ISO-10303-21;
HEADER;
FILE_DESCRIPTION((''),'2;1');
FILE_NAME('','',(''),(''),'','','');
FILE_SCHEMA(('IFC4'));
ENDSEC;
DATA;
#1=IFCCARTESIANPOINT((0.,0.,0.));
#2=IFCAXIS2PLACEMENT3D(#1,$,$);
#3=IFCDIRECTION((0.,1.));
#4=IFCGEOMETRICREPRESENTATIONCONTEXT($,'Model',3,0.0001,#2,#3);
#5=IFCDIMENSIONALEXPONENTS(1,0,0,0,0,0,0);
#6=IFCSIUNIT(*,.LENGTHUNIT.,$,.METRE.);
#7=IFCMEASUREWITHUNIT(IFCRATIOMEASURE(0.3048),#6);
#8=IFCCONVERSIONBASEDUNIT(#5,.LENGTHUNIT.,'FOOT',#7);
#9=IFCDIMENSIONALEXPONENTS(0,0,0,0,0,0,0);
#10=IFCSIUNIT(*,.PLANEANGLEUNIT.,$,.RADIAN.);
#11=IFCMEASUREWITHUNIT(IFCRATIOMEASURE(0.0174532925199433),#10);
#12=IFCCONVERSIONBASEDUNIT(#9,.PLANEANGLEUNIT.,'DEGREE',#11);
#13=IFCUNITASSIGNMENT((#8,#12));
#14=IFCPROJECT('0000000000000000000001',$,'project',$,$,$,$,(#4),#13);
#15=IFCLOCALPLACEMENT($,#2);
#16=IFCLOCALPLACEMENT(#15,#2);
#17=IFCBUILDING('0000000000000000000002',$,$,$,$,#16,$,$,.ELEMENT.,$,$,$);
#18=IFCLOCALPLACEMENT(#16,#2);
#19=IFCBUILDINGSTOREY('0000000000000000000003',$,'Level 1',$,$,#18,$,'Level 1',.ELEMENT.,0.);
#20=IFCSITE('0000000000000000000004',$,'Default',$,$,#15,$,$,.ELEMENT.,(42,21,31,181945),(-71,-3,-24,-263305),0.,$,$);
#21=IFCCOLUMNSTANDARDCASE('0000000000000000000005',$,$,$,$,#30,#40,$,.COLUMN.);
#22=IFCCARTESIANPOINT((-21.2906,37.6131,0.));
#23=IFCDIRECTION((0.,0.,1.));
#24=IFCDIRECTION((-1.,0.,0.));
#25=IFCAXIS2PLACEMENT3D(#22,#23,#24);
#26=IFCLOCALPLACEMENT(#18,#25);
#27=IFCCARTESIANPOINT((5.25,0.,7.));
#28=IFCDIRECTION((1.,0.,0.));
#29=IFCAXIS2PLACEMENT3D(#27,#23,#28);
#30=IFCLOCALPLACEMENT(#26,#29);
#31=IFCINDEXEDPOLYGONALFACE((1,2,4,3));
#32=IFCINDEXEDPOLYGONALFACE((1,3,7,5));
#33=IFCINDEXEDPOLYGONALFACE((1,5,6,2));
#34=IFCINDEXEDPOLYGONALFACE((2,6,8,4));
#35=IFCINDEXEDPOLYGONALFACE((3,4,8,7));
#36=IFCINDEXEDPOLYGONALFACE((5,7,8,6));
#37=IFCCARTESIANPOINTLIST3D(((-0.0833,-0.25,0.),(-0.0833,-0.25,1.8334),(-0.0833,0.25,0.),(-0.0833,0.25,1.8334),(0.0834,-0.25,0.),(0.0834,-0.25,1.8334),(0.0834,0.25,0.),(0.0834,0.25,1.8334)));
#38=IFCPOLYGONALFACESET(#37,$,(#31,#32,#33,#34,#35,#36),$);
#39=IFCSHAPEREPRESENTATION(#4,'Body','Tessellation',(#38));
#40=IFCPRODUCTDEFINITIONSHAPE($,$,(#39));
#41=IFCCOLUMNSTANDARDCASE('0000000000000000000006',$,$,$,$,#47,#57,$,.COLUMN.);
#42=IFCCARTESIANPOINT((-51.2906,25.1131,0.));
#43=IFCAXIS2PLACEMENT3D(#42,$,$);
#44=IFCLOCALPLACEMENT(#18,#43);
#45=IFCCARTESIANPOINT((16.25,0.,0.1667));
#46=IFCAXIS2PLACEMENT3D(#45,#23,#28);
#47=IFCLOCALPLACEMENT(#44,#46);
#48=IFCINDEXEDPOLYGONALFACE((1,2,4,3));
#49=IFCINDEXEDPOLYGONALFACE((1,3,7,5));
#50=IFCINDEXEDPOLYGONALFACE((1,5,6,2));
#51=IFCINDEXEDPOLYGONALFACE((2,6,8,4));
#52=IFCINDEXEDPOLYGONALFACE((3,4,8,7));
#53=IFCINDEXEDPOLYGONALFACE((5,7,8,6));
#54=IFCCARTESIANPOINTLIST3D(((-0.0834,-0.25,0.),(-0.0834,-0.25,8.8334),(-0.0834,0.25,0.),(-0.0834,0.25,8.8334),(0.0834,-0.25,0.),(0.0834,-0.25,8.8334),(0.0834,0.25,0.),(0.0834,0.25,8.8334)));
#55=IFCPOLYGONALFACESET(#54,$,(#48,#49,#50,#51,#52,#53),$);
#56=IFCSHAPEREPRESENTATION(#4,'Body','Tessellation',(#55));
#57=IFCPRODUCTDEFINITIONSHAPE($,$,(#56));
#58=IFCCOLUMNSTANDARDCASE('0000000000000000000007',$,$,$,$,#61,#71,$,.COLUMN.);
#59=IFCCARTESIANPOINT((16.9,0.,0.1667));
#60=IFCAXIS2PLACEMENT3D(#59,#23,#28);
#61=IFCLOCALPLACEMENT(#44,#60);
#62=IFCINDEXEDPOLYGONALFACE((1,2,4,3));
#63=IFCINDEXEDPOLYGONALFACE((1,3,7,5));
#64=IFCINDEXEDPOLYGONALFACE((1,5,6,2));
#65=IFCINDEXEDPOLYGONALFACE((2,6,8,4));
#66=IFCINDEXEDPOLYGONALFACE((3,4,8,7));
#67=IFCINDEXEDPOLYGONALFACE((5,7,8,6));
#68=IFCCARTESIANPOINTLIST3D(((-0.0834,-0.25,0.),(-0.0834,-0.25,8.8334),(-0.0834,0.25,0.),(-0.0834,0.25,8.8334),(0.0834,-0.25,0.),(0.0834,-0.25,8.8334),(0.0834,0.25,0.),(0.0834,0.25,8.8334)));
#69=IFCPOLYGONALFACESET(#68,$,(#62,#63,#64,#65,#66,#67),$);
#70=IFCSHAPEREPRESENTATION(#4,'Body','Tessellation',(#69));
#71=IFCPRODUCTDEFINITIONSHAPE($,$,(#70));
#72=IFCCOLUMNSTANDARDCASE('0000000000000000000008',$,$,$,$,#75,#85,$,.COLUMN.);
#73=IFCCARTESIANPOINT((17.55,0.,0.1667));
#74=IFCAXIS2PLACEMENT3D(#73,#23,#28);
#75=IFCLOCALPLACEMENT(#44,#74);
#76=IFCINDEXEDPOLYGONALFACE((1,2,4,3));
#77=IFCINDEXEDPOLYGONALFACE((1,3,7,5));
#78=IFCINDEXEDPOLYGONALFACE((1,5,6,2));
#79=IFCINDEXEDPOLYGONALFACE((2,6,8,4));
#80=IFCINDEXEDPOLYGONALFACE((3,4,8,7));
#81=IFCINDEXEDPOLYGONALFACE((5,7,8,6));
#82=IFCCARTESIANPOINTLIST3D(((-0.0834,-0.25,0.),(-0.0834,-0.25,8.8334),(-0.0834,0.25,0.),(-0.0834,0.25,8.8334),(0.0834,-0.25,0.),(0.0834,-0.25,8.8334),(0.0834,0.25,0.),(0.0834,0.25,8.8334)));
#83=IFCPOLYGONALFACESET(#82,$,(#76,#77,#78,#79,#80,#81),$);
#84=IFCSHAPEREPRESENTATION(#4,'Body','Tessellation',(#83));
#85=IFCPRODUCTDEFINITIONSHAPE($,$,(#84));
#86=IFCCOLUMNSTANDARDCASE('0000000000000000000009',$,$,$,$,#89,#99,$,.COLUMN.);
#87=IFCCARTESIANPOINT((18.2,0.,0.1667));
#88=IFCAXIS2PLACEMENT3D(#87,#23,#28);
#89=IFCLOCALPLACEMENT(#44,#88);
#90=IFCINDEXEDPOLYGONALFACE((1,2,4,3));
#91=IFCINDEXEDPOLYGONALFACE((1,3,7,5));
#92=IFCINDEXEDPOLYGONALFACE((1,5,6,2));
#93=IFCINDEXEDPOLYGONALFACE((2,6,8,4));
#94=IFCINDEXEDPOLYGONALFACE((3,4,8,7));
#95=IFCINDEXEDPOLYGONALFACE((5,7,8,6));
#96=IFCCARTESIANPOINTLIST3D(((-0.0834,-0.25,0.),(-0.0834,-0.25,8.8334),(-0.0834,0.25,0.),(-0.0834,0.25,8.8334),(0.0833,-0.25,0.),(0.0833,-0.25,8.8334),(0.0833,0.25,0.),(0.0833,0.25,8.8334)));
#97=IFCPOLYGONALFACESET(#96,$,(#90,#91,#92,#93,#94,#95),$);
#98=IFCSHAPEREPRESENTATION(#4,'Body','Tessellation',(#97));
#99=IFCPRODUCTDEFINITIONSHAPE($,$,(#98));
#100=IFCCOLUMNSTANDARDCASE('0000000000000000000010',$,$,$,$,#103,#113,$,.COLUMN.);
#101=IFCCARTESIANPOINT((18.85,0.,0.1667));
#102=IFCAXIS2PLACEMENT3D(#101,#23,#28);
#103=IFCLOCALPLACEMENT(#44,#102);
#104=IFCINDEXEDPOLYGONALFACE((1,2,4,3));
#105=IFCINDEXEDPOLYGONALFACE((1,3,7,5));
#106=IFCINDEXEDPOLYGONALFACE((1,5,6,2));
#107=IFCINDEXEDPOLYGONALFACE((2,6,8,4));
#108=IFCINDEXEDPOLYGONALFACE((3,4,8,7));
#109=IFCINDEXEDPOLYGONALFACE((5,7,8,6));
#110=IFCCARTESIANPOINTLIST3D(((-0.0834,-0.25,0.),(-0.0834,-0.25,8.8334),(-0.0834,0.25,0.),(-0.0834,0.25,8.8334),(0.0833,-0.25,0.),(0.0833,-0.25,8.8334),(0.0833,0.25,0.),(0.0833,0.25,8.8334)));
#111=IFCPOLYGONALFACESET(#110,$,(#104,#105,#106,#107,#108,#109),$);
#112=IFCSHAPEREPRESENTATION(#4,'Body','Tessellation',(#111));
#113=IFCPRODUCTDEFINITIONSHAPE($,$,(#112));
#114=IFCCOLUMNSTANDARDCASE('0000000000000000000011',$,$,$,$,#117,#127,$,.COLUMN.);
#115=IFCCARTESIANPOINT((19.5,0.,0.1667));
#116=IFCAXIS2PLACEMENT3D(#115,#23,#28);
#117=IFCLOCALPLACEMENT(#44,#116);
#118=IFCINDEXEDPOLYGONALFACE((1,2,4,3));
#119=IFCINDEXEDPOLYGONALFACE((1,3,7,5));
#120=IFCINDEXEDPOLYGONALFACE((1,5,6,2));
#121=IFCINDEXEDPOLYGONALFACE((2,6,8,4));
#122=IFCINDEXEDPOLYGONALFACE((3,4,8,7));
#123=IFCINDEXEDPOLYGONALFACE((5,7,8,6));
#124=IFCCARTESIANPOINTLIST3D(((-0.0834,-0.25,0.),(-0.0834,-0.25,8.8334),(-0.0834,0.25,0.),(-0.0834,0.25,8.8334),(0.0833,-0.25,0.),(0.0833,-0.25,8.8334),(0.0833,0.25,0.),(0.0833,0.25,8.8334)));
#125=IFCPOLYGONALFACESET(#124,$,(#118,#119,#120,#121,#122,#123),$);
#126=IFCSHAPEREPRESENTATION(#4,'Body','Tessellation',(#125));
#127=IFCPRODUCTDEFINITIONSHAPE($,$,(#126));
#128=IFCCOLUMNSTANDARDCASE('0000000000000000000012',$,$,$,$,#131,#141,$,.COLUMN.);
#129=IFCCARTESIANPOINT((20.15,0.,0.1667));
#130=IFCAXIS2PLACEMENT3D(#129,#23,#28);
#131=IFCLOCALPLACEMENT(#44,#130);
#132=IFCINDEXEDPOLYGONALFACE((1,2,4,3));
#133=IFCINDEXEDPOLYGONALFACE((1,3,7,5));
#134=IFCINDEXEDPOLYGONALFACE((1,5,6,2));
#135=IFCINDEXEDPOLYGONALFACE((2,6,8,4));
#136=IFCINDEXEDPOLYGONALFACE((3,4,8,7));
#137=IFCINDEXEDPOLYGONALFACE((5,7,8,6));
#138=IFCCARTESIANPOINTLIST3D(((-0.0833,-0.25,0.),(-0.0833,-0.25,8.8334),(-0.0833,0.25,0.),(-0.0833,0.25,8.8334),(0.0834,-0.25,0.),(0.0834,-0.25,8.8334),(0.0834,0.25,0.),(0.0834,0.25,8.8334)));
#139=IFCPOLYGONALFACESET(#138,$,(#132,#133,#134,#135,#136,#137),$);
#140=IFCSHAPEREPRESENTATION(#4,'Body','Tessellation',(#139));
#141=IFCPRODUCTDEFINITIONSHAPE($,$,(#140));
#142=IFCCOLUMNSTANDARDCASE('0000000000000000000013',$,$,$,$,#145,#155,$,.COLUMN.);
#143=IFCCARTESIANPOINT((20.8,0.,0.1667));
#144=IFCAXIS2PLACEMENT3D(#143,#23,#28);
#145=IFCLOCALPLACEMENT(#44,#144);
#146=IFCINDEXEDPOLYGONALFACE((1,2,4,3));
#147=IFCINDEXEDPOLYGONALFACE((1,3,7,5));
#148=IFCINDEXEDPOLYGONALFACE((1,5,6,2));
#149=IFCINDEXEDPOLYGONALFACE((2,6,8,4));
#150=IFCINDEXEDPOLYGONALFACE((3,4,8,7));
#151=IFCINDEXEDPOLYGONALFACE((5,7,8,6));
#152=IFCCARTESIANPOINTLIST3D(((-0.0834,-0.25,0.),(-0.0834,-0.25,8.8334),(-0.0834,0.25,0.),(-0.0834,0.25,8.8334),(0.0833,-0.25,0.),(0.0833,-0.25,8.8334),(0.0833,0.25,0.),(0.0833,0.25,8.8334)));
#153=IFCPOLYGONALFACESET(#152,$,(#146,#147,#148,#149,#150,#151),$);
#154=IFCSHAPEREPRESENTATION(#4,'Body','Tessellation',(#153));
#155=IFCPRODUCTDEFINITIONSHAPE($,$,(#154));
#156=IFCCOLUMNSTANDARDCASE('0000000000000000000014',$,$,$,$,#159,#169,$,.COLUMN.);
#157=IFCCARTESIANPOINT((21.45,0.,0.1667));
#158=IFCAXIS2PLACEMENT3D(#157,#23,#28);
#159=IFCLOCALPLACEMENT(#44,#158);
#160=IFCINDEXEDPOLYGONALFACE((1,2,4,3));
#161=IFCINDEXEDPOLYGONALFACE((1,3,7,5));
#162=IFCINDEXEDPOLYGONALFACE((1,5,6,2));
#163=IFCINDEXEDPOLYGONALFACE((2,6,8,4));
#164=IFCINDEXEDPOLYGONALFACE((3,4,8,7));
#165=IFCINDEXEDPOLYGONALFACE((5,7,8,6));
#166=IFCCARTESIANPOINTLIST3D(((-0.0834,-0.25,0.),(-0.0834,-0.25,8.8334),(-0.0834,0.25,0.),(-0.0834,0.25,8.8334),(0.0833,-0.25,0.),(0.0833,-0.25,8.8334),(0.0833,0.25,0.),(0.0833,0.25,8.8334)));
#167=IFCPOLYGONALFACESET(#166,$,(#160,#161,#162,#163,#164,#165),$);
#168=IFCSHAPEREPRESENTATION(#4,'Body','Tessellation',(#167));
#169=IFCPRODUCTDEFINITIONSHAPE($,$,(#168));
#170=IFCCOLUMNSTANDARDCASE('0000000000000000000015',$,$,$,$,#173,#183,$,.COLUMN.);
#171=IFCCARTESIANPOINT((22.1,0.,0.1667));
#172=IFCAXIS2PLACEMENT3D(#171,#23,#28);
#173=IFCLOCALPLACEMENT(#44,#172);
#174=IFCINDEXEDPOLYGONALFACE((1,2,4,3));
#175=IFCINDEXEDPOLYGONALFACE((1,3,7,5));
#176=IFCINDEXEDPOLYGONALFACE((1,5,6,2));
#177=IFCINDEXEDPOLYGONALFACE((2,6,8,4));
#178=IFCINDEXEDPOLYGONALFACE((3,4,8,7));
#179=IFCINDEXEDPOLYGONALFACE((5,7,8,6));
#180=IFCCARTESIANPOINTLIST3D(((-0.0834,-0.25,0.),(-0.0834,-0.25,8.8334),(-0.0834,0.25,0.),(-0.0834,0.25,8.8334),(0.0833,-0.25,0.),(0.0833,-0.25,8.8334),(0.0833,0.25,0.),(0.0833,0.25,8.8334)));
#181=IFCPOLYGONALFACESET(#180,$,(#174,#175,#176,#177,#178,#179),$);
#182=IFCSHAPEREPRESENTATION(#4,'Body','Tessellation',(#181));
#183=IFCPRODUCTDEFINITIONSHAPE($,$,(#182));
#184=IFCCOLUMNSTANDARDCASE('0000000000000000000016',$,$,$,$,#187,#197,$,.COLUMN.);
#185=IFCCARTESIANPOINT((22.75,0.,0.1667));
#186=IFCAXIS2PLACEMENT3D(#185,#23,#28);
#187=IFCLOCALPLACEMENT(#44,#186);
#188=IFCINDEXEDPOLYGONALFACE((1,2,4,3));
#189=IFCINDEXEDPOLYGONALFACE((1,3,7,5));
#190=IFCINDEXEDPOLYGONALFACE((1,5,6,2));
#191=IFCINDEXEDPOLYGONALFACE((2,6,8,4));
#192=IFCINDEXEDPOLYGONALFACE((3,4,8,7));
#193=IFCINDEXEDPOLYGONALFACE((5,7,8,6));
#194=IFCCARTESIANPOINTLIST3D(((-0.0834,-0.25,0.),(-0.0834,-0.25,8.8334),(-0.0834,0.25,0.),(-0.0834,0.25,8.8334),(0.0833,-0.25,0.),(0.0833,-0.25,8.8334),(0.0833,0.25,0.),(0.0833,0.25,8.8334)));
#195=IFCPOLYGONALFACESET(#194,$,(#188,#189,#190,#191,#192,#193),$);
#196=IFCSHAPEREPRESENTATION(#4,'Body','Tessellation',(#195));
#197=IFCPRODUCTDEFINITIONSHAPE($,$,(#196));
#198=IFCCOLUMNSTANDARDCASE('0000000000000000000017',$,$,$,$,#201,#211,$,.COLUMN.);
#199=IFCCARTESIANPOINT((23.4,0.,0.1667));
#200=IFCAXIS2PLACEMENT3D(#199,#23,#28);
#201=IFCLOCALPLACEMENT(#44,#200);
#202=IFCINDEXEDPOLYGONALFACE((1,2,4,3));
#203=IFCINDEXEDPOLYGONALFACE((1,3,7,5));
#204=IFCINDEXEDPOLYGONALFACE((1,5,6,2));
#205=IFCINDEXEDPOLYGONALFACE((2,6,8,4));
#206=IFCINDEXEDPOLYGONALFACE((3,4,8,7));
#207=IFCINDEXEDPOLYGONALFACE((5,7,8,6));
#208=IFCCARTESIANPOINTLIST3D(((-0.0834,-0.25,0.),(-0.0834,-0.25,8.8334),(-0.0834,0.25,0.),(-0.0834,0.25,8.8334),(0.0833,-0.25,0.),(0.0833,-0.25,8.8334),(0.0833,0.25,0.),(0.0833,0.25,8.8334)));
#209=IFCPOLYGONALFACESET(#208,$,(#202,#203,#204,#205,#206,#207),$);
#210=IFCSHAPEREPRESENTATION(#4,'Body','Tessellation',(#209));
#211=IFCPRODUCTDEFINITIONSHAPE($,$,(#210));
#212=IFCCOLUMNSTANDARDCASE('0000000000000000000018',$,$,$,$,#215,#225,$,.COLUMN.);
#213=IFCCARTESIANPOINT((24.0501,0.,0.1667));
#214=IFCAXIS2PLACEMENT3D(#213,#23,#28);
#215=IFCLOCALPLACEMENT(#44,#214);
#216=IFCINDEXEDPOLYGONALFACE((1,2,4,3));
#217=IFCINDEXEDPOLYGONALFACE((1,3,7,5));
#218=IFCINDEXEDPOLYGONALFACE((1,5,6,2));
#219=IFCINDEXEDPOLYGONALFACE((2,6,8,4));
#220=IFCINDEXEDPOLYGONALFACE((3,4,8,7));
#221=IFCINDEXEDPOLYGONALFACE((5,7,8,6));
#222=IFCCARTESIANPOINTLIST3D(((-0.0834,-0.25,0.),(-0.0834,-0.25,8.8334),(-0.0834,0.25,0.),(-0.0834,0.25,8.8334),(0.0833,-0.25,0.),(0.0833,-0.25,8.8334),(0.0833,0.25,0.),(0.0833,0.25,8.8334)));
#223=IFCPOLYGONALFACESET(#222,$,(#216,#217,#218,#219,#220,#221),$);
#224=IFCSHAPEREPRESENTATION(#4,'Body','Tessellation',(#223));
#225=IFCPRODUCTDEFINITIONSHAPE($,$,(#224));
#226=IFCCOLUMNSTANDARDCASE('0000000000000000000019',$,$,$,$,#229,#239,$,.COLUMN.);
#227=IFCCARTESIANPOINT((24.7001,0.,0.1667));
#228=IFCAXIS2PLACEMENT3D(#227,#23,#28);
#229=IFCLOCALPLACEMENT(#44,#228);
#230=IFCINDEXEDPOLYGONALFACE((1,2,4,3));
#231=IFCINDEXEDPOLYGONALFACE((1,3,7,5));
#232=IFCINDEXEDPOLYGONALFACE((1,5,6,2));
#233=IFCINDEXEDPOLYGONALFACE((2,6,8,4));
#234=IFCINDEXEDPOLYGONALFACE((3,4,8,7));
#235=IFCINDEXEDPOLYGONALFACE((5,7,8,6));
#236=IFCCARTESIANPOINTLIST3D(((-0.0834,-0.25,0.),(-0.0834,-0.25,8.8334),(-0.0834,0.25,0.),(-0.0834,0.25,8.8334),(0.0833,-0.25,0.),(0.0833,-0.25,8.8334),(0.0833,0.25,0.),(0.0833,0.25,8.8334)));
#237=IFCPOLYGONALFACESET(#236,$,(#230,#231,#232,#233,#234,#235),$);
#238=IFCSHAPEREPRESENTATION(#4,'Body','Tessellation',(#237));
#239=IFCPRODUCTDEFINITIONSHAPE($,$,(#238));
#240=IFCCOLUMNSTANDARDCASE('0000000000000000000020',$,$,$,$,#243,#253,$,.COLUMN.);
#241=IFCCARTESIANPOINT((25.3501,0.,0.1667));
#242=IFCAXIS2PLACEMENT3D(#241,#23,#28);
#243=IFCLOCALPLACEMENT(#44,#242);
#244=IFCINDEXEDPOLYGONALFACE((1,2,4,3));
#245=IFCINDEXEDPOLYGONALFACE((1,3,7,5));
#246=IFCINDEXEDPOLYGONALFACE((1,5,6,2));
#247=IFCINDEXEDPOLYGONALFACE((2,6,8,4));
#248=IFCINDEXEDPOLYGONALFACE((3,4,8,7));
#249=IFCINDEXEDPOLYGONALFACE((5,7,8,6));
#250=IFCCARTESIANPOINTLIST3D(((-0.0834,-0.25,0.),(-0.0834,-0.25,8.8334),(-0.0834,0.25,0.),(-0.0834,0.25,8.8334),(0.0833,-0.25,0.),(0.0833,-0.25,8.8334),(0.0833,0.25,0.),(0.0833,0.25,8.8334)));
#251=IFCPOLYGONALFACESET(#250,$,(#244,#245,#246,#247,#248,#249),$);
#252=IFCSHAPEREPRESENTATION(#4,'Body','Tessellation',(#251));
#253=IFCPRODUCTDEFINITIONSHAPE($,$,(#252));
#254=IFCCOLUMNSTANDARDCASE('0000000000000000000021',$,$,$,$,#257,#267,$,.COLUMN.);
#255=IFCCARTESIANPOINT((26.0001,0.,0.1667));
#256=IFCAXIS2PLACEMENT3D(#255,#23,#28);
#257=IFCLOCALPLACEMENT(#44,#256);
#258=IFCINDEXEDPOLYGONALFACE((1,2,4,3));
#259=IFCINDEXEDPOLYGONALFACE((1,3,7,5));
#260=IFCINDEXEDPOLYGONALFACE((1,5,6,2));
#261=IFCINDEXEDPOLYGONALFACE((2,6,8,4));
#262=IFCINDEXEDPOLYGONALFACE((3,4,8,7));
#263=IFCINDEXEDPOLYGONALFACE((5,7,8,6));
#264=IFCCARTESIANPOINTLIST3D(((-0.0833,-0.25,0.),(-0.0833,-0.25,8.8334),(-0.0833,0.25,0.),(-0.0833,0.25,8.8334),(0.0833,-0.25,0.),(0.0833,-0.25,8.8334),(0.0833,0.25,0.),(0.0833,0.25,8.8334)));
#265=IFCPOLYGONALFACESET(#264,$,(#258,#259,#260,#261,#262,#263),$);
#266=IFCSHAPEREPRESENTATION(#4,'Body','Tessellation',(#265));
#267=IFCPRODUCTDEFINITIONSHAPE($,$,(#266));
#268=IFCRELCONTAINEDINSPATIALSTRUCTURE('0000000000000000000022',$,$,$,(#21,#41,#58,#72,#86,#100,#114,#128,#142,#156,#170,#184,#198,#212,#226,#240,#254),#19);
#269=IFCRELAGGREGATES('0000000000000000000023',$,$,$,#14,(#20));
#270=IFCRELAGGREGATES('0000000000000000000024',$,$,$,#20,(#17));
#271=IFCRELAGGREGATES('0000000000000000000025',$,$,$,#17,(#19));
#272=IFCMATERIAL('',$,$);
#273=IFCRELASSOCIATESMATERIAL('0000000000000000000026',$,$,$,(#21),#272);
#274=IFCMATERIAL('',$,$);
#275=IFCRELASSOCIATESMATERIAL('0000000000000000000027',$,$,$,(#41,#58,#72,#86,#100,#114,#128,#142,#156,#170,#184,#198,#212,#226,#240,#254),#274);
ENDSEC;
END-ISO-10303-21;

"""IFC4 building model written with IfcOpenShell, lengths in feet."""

from ifc_helpers import new_model, entity, si_unit, converted_unit, direction, frame, origin, place, context, project, spatial, rectangle, extrude, material, element, save


model = new_model("IFC4")

# Units and contexts
model_context = context("Model", 3, precision=0.0001, world=origin(), true_north=direction((0.0, 1.0)))
ifc_project = project(units=[converted_unit("LENGTHUNIT", "FOOT", entity("IfcRatioMeasure", 0.3048), si_unit("LENGTHUNIT", "METRE"), dimensions=[1, 0, 0, 0, 0, 0, 0]), converted_unit("PLANEANGLEUNIT", "DEGREE", entity("IfcRatioMeasure", 0.0174532925199433), si_unit("PLANEANGLEUNIT", "RADIAN"), dimensions=[0, 0, 0, 0, 0, 0, 0])], contexts=[model_context])

# Site, building, storey
site_placement = place(None, origin())
site = spatial("IfcSite", under=ifc_project, at=site_placement, Name="Default", CompositionType="ELEMENT", RefLatitude=(42, 21, 31, 181945), RefLongitude=(-71, -3, -24, -263305), RefElevation=0.0)
building_placement = place(site_placement, origin())
building = spatial("IfcBuilding", under=site, at=building_placement, CompositionType="ELEMENT")
storey_placement = place(building_placement, origin())
storey = spatial("IfcBuildingStorey", under=building, at=storey_placement, Name="Level 1", LongName="Level 1", CompositionType="ELEMENT", Elevation=0.0)

# Columns
placement_1 = place(storey_placement, frame((-21.2906, 37.6131, 0.0), z_axis=(0.0, 0.0, 1.0), x_axis=(-1.0, 0.0, 0.0)))
ifc_material_1 = material(Name="")
for number, where, z_axis, x_axis in (
    (1, (5.25, 0.0, 7.0), (0.0, 0.0, 1.0), (1.0, 0.0, 0.0)),
):
    element("IfcColumnStandardCase", number, at=place(placement_1, frame(where, z_axis=z_axis, x_axis=x_axis)), inside=storey, material=ifc_material_1, PredefinedType="COLUMN", context=model_context, shape_type="SweptSolid", body=[
        extrude(rectangle(XDim=0.1667, YDim=0.5), origin(), (0.0, 0.0, 1.0), 1.8334),
    ])
ifc_material_2 = material(Name="")
placement_2 = place(storey_placement, frame((-51.2906, 25.1131, 0.0)))
for number, where, z_axis, x_axis in (
    (2, (16.25, 0.0, 0.1667), (0.0, 0.0, 1.0), (1.0, 0.0, 0.0)),
    (3, (16.9, 0.0, 0.1667), (0.0, 0.0, 1.0), (1.0, 0.0, 0.0)),
    (4, (17.55, 0.0, 0.1667), (0.0, 0.0, 1.0), (1.0, 0.0, 0.0)),
    (5, (18.2, 0.0, 0.1667), (0.0, 0.0, 1.0), (1.0, 0.0, 0.0)),
    (6, (18.85, 0.0, 0.1667), (0.0, 0.0, 1.0), (1.0, 0.0, 0.0)),
    (7, (19.5, 0.0, 0.1667), (0.0, 0.0, 1.0), (1.0, 0.0, 0.0)),
    (8, (20.15, 0.0, 0.1667), (0.0, 0.0, 1.0), (1.0, 0.0, 0.0)),
    (9, (20.8, 0.0, 0.1667), (0.0, 0.0, 1.0), (1.0, 0.0, 0.0)),
    (10, (21.45, 0.0, 0.1667), (0.0, 0.0, 1.0), (1.0, 0.0, 0.0)),
    (11, (22.1, 0.0, 0.1667), (0.0, 0.0, 1.0), (1.0, 0.0, 0.0)),
    (12, (22.75, 0.0, 0.1667), (0.0, 0.0, 1.0), (1.0, 0.0, 0.0)),
    (13, (23.4, 0.0, 0.1667), (0.0, 0.0, 1.0), (1.0, 0.0, 0.0)),
    (14, (24.0501, 0.0, 0.1667), (0.0, 0.0, 1.0), (1.0, 0.0, 0.0)),
    (15, (24.7001, 0.0, 0.1667), (0.0, 0.0, 1.0), (1.0, 0.0, 0.0)),
    (16, (25.3501, 0.0, 0.1667), (0.0, 0.0, 1.0), (1.0, 0.0, 0.0)),
    (17, (26.0001, 0.0, 0.1667), (0.0, 0.0, 1.0), (1.0, 0.0, 0.0)),
):
    element("IfcColumnStandardCase", number, at=place(placement_2, frame(where, z_axis=z_axis, x_axis=x_axis)), inside=storey, material=ifc_material_2, PredefinedType="COLUMN", context=model_context, shape_type="SweptSolid", body=[
        extrude(rectangle(XDim=0.1667, YDim=0.5), origin(), (0.0, 0.0, 1.0), 8.8334),
    ])

save(model, "model.ifc")
